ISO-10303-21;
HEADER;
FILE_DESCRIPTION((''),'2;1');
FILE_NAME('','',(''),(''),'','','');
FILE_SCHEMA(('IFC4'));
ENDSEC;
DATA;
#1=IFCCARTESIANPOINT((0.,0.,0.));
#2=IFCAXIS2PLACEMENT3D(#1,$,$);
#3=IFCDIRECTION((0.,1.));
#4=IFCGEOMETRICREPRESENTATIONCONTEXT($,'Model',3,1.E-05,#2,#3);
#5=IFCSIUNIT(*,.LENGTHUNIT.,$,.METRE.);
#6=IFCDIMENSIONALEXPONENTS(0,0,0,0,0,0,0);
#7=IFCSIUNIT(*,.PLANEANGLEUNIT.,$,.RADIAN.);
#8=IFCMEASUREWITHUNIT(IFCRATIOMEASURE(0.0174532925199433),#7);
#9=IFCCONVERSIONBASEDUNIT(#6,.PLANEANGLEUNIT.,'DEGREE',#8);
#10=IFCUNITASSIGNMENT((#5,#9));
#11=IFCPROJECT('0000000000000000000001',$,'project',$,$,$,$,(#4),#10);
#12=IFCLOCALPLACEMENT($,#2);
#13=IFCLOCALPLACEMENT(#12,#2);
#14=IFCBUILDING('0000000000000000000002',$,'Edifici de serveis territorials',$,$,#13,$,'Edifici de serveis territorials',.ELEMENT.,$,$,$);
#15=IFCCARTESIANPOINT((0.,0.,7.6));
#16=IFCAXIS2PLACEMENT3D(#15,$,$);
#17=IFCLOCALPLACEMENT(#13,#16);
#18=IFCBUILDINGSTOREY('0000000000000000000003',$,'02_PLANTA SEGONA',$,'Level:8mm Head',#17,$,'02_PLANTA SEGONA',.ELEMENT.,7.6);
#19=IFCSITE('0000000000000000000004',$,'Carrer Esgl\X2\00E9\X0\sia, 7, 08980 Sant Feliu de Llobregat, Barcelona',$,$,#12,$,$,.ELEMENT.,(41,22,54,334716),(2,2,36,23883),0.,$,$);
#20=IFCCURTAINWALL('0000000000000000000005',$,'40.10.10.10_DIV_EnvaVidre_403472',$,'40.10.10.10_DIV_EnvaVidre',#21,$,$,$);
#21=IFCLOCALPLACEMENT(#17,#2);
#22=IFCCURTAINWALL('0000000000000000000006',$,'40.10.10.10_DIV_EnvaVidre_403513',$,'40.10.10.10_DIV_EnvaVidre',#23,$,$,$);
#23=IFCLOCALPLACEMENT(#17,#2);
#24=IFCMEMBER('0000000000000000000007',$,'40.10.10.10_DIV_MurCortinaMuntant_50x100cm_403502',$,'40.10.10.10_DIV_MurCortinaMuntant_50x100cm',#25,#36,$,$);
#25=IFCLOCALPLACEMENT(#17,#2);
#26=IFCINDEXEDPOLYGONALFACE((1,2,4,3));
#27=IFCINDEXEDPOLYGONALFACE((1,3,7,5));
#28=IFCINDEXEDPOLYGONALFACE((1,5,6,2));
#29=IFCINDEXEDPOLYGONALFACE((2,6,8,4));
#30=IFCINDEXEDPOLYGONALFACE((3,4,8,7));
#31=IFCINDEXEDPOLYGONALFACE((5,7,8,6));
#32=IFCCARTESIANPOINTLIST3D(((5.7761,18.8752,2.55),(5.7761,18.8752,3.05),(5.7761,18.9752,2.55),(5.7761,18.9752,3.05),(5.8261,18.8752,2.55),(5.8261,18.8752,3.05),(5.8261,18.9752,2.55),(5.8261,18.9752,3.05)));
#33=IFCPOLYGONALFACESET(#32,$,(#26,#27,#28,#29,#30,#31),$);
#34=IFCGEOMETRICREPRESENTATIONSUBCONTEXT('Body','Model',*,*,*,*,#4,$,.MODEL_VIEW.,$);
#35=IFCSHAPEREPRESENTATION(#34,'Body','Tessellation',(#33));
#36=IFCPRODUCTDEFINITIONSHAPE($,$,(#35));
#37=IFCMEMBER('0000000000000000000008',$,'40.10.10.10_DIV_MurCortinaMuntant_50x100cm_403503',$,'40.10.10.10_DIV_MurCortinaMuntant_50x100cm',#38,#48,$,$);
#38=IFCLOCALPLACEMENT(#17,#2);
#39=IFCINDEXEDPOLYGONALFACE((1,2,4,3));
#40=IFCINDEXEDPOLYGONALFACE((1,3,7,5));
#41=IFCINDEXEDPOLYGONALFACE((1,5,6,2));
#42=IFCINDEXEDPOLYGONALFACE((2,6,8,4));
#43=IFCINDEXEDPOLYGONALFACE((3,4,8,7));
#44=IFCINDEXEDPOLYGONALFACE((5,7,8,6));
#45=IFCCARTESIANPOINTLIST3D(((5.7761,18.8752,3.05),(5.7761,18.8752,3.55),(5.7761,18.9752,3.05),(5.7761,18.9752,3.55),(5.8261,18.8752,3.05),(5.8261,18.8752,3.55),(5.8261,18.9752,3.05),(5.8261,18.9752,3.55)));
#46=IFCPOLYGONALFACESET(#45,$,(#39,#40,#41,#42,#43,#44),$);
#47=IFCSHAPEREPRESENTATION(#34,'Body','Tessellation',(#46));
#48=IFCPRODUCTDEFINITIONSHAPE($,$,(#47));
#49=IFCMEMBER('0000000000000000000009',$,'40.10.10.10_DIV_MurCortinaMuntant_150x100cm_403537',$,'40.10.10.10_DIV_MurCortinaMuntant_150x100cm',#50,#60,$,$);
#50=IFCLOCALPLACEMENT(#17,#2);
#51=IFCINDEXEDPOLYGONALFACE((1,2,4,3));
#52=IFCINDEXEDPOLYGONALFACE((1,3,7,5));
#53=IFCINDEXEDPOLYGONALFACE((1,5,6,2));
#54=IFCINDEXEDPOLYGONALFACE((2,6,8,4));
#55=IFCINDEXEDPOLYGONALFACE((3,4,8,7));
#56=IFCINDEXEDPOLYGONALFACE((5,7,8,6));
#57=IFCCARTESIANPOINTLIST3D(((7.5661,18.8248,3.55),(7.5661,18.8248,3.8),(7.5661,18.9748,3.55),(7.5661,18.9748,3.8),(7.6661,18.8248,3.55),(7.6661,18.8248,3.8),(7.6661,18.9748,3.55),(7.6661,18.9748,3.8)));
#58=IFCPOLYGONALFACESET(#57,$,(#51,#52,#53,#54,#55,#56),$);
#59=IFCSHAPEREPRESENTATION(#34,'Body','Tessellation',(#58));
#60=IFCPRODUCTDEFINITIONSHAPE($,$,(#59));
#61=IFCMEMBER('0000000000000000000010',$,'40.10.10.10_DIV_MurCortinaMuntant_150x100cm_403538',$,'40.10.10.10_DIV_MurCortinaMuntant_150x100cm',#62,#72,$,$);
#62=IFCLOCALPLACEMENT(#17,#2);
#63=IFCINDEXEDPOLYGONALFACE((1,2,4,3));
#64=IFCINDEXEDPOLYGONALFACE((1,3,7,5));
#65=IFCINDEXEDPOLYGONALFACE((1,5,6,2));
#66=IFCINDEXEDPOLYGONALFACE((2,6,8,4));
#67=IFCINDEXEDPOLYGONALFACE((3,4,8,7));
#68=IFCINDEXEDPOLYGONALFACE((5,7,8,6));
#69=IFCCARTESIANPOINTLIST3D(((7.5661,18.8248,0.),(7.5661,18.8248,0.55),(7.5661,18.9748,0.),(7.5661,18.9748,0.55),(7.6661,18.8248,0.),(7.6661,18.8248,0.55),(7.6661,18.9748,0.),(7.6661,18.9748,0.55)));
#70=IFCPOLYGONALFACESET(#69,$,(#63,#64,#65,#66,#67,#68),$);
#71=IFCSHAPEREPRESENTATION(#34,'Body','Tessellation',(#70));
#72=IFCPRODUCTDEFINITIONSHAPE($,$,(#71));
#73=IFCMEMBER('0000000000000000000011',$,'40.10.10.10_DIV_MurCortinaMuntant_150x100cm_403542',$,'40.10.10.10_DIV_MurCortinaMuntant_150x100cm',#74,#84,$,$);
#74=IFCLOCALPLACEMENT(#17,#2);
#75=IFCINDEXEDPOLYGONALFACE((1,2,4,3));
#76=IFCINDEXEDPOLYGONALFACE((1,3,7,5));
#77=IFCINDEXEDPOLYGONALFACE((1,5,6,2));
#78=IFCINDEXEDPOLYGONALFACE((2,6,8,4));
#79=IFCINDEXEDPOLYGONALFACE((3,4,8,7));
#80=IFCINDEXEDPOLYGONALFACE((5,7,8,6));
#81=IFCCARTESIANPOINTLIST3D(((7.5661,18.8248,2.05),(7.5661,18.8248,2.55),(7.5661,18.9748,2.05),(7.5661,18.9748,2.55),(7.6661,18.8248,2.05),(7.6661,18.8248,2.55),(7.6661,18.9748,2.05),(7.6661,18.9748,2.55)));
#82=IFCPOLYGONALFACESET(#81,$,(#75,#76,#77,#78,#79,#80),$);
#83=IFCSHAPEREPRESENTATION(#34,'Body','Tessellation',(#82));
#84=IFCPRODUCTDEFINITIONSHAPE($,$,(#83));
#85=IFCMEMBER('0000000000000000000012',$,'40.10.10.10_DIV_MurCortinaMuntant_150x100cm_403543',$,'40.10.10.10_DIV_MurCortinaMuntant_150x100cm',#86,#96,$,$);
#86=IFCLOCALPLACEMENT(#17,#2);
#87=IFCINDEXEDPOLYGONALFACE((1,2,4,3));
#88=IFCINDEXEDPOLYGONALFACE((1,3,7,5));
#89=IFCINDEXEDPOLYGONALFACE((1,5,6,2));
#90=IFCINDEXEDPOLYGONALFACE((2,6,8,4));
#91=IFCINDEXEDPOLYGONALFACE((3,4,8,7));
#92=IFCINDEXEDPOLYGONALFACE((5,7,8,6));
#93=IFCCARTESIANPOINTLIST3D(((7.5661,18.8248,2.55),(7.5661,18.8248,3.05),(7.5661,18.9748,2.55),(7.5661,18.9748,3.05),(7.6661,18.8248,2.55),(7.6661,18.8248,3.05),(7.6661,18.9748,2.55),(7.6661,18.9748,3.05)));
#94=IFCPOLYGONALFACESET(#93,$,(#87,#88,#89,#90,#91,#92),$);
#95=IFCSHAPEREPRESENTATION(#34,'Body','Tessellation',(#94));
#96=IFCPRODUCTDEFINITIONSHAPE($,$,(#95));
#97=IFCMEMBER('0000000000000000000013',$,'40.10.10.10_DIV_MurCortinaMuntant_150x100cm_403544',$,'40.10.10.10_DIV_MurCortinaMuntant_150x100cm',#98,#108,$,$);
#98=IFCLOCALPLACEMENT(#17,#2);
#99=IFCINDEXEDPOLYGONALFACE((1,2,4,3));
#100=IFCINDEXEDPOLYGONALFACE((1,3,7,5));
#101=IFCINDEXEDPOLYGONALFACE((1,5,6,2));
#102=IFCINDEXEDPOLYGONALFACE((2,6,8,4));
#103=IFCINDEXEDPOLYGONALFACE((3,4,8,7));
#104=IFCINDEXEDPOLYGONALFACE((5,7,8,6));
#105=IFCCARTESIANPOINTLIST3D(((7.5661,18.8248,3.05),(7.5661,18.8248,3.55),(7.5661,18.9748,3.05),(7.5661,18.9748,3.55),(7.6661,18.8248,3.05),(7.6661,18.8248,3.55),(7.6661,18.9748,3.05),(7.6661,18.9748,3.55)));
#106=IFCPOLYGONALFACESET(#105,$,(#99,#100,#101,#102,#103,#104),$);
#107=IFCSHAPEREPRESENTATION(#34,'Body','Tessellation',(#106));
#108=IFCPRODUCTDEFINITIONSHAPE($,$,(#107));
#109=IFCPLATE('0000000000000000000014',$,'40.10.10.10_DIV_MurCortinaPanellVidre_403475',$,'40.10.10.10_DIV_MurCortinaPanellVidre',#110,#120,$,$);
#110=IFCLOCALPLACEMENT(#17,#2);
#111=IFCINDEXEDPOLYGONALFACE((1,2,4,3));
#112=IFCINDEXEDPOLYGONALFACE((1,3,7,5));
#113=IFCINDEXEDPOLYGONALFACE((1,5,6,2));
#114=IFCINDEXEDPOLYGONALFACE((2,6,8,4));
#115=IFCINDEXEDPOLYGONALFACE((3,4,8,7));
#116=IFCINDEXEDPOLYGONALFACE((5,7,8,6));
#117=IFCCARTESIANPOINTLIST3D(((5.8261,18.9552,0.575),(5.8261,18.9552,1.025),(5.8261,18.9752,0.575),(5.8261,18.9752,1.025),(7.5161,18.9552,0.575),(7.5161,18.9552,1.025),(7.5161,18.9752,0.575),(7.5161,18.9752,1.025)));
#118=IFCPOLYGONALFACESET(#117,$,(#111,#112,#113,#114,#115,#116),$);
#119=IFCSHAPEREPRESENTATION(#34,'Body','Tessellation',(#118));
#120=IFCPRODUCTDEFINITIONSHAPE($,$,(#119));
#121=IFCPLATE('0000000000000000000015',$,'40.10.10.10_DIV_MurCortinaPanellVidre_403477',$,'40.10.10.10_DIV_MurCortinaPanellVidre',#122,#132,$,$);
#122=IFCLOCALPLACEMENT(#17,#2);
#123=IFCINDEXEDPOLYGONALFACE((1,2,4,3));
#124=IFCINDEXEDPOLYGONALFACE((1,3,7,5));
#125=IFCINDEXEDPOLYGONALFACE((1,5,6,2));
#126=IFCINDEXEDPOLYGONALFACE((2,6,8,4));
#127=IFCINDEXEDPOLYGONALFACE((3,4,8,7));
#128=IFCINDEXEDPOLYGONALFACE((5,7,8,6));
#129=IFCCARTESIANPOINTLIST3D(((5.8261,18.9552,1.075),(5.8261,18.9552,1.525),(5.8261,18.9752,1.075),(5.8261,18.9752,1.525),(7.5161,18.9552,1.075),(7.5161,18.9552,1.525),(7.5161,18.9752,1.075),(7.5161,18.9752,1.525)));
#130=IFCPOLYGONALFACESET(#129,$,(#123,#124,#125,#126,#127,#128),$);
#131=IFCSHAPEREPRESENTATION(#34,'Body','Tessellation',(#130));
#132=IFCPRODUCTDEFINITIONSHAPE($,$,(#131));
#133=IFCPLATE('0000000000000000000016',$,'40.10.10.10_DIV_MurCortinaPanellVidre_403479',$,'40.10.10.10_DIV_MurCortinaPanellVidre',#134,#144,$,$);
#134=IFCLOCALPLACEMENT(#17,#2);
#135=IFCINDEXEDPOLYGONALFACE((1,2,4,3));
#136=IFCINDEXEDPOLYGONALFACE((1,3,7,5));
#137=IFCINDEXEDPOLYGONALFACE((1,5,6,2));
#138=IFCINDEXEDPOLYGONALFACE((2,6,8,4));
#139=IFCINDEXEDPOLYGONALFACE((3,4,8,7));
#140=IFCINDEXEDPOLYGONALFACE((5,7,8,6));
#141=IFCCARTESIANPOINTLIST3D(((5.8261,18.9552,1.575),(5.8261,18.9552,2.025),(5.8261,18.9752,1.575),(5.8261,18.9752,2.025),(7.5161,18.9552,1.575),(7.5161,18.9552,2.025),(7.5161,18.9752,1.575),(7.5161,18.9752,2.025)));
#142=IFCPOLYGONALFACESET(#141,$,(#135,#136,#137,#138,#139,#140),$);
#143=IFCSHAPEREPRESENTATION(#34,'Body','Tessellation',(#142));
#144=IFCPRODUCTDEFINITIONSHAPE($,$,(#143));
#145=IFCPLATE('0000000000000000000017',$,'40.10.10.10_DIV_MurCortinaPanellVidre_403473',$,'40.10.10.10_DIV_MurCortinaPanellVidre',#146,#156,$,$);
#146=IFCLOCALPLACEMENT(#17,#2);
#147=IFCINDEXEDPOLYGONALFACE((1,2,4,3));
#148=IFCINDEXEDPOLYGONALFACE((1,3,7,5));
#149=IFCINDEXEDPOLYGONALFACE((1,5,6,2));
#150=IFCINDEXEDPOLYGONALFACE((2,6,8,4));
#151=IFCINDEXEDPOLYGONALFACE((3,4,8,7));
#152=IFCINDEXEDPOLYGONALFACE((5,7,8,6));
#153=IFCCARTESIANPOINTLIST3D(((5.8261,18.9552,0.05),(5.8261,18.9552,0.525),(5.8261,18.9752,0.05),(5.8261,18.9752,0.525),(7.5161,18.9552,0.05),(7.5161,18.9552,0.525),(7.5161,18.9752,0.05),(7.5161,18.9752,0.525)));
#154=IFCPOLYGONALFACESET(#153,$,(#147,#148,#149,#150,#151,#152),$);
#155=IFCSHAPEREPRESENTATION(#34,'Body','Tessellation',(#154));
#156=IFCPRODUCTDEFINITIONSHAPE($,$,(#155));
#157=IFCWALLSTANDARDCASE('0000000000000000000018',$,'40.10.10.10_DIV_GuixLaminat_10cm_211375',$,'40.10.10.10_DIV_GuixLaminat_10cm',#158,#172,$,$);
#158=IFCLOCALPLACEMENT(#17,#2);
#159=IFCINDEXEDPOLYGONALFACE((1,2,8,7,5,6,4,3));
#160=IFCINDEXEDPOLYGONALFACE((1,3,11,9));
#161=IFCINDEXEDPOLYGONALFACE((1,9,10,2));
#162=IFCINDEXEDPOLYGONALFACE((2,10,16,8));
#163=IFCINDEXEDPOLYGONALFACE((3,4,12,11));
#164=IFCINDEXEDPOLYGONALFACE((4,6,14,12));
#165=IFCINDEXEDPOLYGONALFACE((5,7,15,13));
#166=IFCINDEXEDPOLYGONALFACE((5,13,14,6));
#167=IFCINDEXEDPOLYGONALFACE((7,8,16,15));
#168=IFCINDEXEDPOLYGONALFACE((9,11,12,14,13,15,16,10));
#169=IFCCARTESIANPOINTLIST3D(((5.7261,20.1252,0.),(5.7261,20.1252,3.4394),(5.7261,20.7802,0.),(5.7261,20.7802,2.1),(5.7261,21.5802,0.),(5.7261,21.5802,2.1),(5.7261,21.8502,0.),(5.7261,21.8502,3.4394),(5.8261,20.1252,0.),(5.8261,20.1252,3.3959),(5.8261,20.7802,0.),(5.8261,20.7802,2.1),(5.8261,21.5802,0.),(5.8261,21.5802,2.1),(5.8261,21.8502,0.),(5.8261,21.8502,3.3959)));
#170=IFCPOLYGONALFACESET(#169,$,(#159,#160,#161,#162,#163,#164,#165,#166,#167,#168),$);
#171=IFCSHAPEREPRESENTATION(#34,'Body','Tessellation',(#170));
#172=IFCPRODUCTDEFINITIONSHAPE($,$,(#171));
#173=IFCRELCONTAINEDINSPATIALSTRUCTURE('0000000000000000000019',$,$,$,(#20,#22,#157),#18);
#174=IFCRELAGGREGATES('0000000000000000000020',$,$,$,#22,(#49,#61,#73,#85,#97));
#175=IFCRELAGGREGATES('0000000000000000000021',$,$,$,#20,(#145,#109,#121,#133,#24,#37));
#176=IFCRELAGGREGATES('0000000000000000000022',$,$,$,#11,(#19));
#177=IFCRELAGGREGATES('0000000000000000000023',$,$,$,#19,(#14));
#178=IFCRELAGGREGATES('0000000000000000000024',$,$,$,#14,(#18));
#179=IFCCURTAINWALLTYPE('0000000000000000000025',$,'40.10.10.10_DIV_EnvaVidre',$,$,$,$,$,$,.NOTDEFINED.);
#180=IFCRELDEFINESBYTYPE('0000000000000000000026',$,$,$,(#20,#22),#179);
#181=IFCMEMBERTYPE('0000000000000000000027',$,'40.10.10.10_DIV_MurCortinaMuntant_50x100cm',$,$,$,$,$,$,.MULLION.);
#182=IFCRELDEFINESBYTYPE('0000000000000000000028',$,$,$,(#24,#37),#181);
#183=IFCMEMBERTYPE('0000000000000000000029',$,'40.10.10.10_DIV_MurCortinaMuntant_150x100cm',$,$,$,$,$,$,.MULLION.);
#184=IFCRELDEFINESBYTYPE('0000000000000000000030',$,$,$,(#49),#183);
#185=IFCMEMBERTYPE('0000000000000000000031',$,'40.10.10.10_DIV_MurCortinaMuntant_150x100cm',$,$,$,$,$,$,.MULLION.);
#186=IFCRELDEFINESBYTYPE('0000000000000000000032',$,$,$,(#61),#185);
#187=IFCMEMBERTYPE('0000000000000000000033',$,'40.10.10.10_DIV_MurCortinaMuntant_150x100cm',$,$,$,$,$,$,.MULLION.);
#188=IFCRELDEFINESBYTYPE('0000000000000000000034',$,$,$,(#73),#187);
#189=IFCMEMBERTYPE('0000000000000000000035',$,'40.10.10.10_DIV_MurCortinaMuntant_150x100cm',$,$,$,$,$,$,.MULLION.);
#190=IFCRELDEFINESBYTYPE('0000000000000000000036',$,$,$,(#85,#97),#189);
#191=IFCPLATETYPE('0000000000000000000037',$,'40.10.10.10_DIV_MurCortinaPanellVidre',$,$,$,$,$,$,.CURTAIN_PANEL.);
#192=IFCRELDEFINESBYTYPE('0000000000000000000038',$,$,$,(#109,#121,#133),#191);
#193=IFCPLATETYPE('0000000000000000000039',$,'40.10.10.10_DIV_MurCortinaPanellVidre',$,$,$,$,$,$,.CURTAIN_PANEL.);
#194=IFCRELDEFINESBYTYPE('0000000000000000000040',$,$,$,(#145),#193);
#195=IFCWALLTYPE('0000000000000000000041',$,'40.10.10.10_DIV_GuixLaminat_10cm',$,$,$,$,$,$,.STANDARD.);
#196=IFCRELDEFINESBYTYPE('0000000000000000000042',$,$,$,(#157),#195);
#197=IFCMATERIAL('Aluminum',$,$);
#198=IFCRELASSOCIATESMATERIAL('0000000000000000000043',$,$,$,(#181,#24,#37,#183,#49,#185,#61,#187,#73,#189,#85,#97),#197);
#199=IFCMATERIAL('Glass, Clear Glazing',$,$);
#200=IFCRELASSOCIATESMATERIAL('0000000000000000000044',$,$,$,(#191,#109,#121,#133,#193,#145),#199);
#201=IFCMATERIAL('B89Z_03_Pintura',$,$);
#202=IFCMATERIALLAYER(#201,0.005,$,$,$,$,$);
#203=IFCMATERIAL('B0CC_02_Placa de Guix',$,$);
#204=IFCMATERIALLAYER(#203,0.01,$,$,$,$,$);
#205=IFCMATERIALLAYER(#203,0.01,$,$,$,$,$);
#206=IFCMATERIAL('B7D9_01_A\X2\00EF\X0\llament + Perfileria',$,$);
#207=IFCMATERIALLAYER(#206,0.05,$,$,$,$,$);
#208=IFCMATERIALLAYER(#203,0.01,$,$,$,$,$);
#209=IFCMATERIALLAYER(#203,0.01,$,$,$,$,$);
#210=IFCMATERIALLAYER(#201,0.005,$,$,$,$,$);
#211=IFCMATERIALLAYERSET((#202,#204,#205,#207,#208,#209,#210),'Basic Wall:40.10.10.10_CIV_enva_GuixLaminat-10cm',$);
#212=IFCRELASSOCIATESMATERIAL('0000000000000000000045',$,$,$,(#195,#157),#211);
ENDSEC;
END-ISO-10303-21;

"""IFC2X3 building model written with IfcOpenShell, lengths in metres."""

from ifc_helpers import new_model, entity, si_unit, converted_unit, direction, frame, frame_2d, origin, origin_2d_with_axis, place, context, subcontext, project, spatial, polyline, rectangle, extrude, clip, bounded_halfspace, source, transform, mapped, material, layer, layer_set, layer_usage, type_object, type_shapes, element, aggregate, save


model = new_model("IFC2X3")

# Units and contexts
model_context = context("Model", 3, precision=1e-05, world=origin(), true_north=direction((0.0, 1.0)))
body_context = subcontext(model_context, "Body", "Model", "MODEL_VIEW")
ifc_project = project(units=[si_unit("LENGTHUNIT", "METRE"), converted_unit("PLANEANGLEUNIT", "DEGREE", entity("IfcRatioMeasure", 0.0174532925199433), si_unit("PLANEANGLEUNIT", "RADIAN"), dimensions=[0, 0, 0, 0, 0, 0, 0])], contexts=[model_context])

# Site, building, storey
site_placement = place(None, origin())
site = spatial("IfcSite", under=ifc_project, at=site_placement, Name="Carrer Església, 7, 08980 Sant Feliu de Llobregat, Barcelona", CompositionType="ELEMENT", RefLatitude=(41, 22, 54, 334716), RefLongitude=(2, 2, 36, 23883), RefElevation=0.0)
building_placement = place(site_placement, origin())
building = spatial("IfcBuilding", under=site, at=building_placement, Name="Edifici de serveis territorials", LongName="Edifici de serveis territorials", CompositionType="ELEMENT")
storey_placement = place(building_placement, frame((0.0, 0.0, 7.6)))
storey = spatial("IfcBuildingStorey", under=building, at=storey_placement, Name="02_PLANTA SEGONA", ObjectType="Level:8mm Head", LongName="02_PLANTA SEGONA", CompositionType="ELEMENT", Elevation=7.6)

# Curtain walls
curtain_wall_type = type_object("IfcCurtainWallType", Name="40.10.10.10_DIV_EnvaVidre", PredefinedType="NOTDEFINED")
curtain_wall_1_placement = place(storey_placement, frame((0.0, 0.0, -7.6)))
curtain_wall_1 = element("IfcCurtainWall", 1, at=curtain_wall_1_placement, inside=storey, type_object=curtain_wall_type, Name="40.10.10.10_DIV_EnvaVidre_403472", ObjectType="40.10.10.10_DIV_EnvaVidre")
ifc_material_1 = material(Name="Aluminum")
curtain_wall_2_placement = place(storey_placement, frame((0.0, 0.0, -7.6)))
curtain_wall_2 = element("IfcCurtainWall", 2, at=curtain_wall_2_placement, inside=storey, type_object=curtain_wall_type, Name="40.10.10.10_DIV_EnvaVidre_403513", ObjectType="40.10.10.10_DIV_EnvaVidre")

# Members
member_type_1 = type_object("IfcMemberType", Name="40.10.10.10_DIV_MurCortinaMuntant_50x100cm", PredefinedType="MULLION", material=ifc_material_1)
shared_shape_1 = source(origin(), body_context, "Body", "SweptSolid", [
    extrude(rectangle(XDim=0.1, YDim=0.05, at=origin_2d_with_axis()), frame((-0.025, 0.0, -0.5), z_axis=(0.0, 0.0, 1.0), x_axis=(0.0, -1.0, 0.0)), (0.0, 0.0, 1.0), 0.5),
])
type_shapes(member_type_1, [shared_shape_1])
member_1_placement = place(storey_placement, frame((5.7761, 18.9252, 3.05), z_axis=(0.0, 0.0, 1.0), x_axis=(-1.0, 0.0, 0.0)))
member_1 = element("IfcMember", 3, at=member_1_placement, type_object=member_type_1, material=ifc_material_1, Name="40.10.10.10_DIV_MurCortinaMuntant_50x100cm_403502", ObjectType="40.10.10.10_DIV_MurCortinaMuntant_50x100cm", context=body_context, shape_type="MappedRepresentation", body=[
    mapped(shared_shape_1, transform((0.0, 0.0, 0.0), scale=1.0)),
])
member_2_placement = place(storey_placement, frame((5.7761, 18.9252, 3.55), z_axis=(0.0, 0.0, 1.0), x_axis=(-1.0, 0.0, 0.0)))
member_2 = element("IfcMember", 4, at=member_2_placement, type_object=member_type_1, material=ifc_material_1, Name="40.10.10.10_DIV_MurCortinaMuntant_50x100cm_403503", ObjectType="40.10.10.10_DIV_MurCortinaMuntant_50x100cm", context=body_context, shape_type="MappedRepresentation", body=[
    mapped(shared_shape_1, transform((0.0, 0.0, 0.0), scale=1.0)),
])
member_type_2 = type_object("IfcMemberType", Name="40.10.10.10_DIV_MurCortinaMuntant_150x100cm", PredefinedType="MULLION", material=ifc_material_1)
shared_shape_2 = source(origin(), body_context, "Body", "SweptSolid", [
    extrude(rectangle(XDim=0.1, YDim=0.15, at=origin_2d_with_axis()), frame((-0.075, 0.0, -0.25), z_axis=(0.0, 0.0, 1.0), x_axis=(0.0, -1.0, 0.0)), (0.0, 0.0, 1.0), 0.25),
])
type_shapes(member_type_2, [shared_shape_2])
member_3_placement = place(storey_placement, frame((7.6161, 18.9748, 3.8), z_axis=(0.0, 0.0, 1.0), x_axis=(0.0, 1.0, 0.0)))
member_3 = element("IfcMember", 5, at=member_3_placement, type_object=member_type_2, material=ifc_material_1, Name="40.10.10.10_DIV_MurCortinaMuntant_150x100cm_403537", ObjectType="40.10.10.10_DIV_MurCortinaMuntant_150x100cm", context=body_context, shape_type="MappedRepresentation", body=[
    mapped(shared_shape_2, transform((0.0, 0.0, 0.0), scale=1.0)),
])
member_type_3 = type_object("IfcMemberType", Name="40.10.10.10_DIV_MurCortinaMuntant_150x100cm", PredefinedType="MULLION", material=ifc_material_1)
shared_shape_3 = source(origin(), body_context, "Body", "SweptSolid", [
    extrude(rectangle(XDim=0.1, YDim=0.15, at=origin_2d_with_axis()), frame((-0.075, 0.0, -0.55), z_axis=(0.0, 0.0, 1.0), x_axis=(0.0, -1.0, 0.0)), (0.0, 0.0, 1.0), 0.55),
])
type_shapes(member_type_3, [shared_shape_3])
member_4_placement = place(storey_placement, frame((7.6161, 18.9748, 0.55), z_axis=(0.0, 0.0, 1.0), x_axis=(0.0, 1.0, 0.0)))
member_4 = element("IfcMember", 6, at=member_4_placement, type_object=member_type_3, material=ifc_material_1, Name="40.10.10.10_DIV_MurCortinaMuntant_150x100cm_403538", ObjectType="40.10.10.10_DIV_MurCortinaMuntant_150x100cm", context=body_context, shape_type="MappedRepresentation", body=[
    mapped(shared_shape_3, transform((0.0, 0.0, 0.0), scale=1.0)),
])
member_type_4 = type_object("IfcMemberType", Name="40.10.10.10_DIV_MurCortinaMuntant_150x100cm", PredefinedType="MULLION", material=ifc_material_1)
shared_shape_4 = source(origin(), body_context, "Body", "SweptSolid", [
    extrude(rectangle(XDim=0.1, YDim=0.15, at=origin_2d_with_axis()), frame((-0.075, 0.0, -0.5), z_axis=(0.0, 0.0, 1.0), x_axis=(0.0, -1.0, 0.0)), (0.0, 0.0, 1.0), 0.5),
])
type_shapes(member_type_4, [shared_shape_4])
member_5_placement = place(storey_placement, frame((7.6161, 18.9748, 2.55), z_axis=(0.0, 0.0, 1.0), x_axis=(0.0, 1.0, 0.0)))
member_5 = element("IfcMember", 7, at=member_5_placement, type_object=member_type_4, material=ifc_material_1, Name="40.10.10.10_DIV_MurCortinaMuntant_150x100cm_403542", ObjectType="40.10.10.10_DIV_MurCortinaMuntant_150x100cm", context=body_context, shape_type="MappedRepresentation", body=[
    mapped(shared_shape_4, transform((0.0, 0.0, 0.0), scale=1.0)),
])
member_type_5 = type_object("IfcMemberType", Name="40.10.10.10_DIV_MurCortinaMuntant_150x100cm", PredefinedType="MULLION", material=ifc_material_1)
shared_shape_5 = source(origin(), body_context, "Body", "SweptSolid", [
    extrude(rectangle(XDim=0.1, YDim=0.15, at=origin_2d_with_axis()), frame((-0.075, 0.0, -0.5), z_axis=(0.0, 0.0, 1.0), x_axis=(0.0, -1.0, 0.0)), (0.0, 0.0, 1.0), 0.5),
])
type_shapes(member_type_5, [shared_shape_5])
member_6_placement = place(storey_placement, frame((7.6161, 18.9748, 3.05), z_axis=(0.0, 0.0, 1.0), x_axis=(0.0, 1.0, 0.0)))
member_6 = element("IfcMember", 8, at=member_6_placement, type_object=member_type_5, material=ifc_material_1, Name="40.10.10.10_DIV_MurCortinaMuntant_150x100cm_403543", ObjectType="40.10.10.10_DIV_MurCortinaMuntant_150x100cm", context=body_context, shape_type="MappedRepresentation", body=[
    mapped(shared_shape_5, transform((0.0, 0.0, 0.0), scale=1.0)),
])
member_7_placement = place(storey_placement, frame((7.6161, 18.9748, 3.55), z_axis=(0.0, 0.0, 1.0), x_axis=(0.0, 1.0, 0.0)))
member_7 = element("IfcMember", 9, at=member_7_placement, type_object=member_type_5, material=ifc_material_1, Name="40.10.10.10_DIV_MurCortinaMuntant_150x100cm_403544", ObjectType="40.10.10.10_DIV_MurCortinaMuntant_150x100cm", context=body_context, shape_type="MappedRepresentation", body=[
    mapped(shared_shape_5, transform((0.0, 0.0, 0.0), scale=1.0)),
])
aggregate(curtain_wall_2, [member_3, member_4, member_5, member_6, member_7])

# Plates
ifc_material_2 = material(Name="Glass, Clear Glazing")
plate_type_1 = type_object("IfcPlateType", Name="40.10.10.10_DIV_MurCortinaPanellVidre", PredefinedType="CURTAIN_PANEL", material=ifc_material_2)
shared_shape_6 = source(origin(), body_context, "Body", "SweptSolid", [
    extrude(rectangle(XDim=0.02, YDim=1.69, at=frame_2d((0.0, 0.0), x_axis=(1.0, 0.0))), frame((0.845, 0.01, 0.0), z_axis=(0.0, 0.0, 1.0), x_axis=(0.0, 1.0, 0.0)), (0.0, 0.0, 1.0), 0.45),
])
type_shapes(plate_type_1, [shared_shape_6])
plate_1_placement = place(curtain_wall_1_placement, frame((5.8261, 18.9552, 8.175)))
plate_1 = element("IfcPlate", 10, at=plate_1_placement, type_object=plate_type_1, material=ifc_material_2, Name="40.10.10.10_DIV_MurCortinaPanellVidre_403475", ObjectType="40.10.10.10_DIV_MurCortinaPanellVidre", context=body_context, shape_type="MappedRepresentation", body=[
    mapped(shared_shape_6, transform((0.0, 0.0, 0.0), scale=1.0)),
])
plate_2_placement = place(curtain_wall_1_placement, frame((5.8261, 18.9552, 8.675)))
plate_2 = element("IfcPlate", 11, at=plate_2_placement, type_object=plate_type_1, material=ifc_material_2, Name="40.10.10.10_DIV_MurCortinaPanellVidre_403477", ObjectType="40.10.10.10_DIV_MurCortinaPanellVidre", context=body_context, shape_type="MappedRepresentation", body=[
    mapped(shared_shape_6, transform((0.0, 0.0, 0.0), scale=1.0)),
])
plate_3_placement = place(curtain_wall_1_placement, frame((5.8261, 18.9552, 9.175)))
plate_3 = element("IfcPlate", 12, at=plate_3_placement, type_object=plate_type_1, material=ifc_material_2, Name="40.10.10.10_DIV_MurCortinaPanellVidre_403479", ObjectType="40.10.10.10_DIV_MurCortinaPanellVidre", context=body_context, shape_type="MappedRepresentation", body=[
    mapped(shared_shape_6, transform((0.0, 0.0, 0.0), scale=1.0)),
])
plate_type_2 = type_object("IfcPlateType", Name="40.10.10.10_DIV_MurCortinaPanellVidre", PredefinedType="CURTAIN_PANEL", material=ifc_material_2)
shared_shape_7 = source(origin(), body_context, "Body", "SweptSolid", [
    extrude(rectangle(XDim=0.02, YDim=1.69, at=frame_2d((0.0, 0.0), x_axis=(1.0, 0.0))), frame((0.845, 0.01, 0.0), z_axis=(0.0, 0.0, 1.0), x_axis=(0.0, 1.0, 0.0)), (0.0, 0.0, 1.0), 0.475),
])
type_shapes(plate_type_2, [shared_shape_7])
plate_4_placement = place(curtain_wall_1_placement, frame((5.8261, 18.9552, 7.65)))
plate_4 = element("IfcPlate", 13, at=plate_4_placement, type_object=plate_type_2, material=ifc_material_2, Name="40.10.10.10_DIV_MurCortinaPanellVidre_403473", ObjectType="40.10.10.10_DIV_MurCortinaPanellVidre", context=body_context, shape_type="MappedRepresentation", body=[
    mapped(shared_shape_7, transform((0.0, 0.0, 0.0), scale=1.0)),
])
aggregate(curtain_wall_1, [plate_4, plate_1, plate_2, plate_3, member_1, member_2])

# Wall, opening
ifc_material_3 = material(Name="B89Z_03_Pintura")
ifc_layer_1 = layer(ifc_material_3, 0.005)
ifc_material_4 = material(Name="B0CC_02_Placa de Guix")
ifc_layer_2 = layer(ifc_material_4, 0.01)
ifc_layer_3 = layer(ifc_material_4, 0.01)
ifc_material_5 = material(Name="B7D9_01_Aïllament + Perfileria")
ifc_layer_4 = layer(ifc_material_5, 0.05)
ifc_layer_5 = layer(ifc_material_4, 0.01)
ifc_layer_6 = layer(ifc_material_4, 0.01)
ifc_layer_7 = layer(ifc_material_3, 0.005)
ifc_layer_set_1 = layer_set([ifc_layer_1, ifc_layer_2, ifc_layer_3, ifc_layer_4, ifc_layer_5, ifc_layer_6, ifc_layer_7], Name="Basic Wall:40.10.10.10_CIV_enva_GuixLaminat-10cm")
ifc_layer_usage_1 = layer_usage(ifc_layer_set_1, "AXIS2", "NEGATIVE", 0.05)
wall_type_1 = type_object("IfcWallType", Name="40.10.10.10_DIV_GuixLaminat_10cm", PredefinedType="STANDARD", material=ifc_layer_set_1)
wall_1_placement = place(storey_placement, frame((5.7761, 21.8502, 0.0), z_axis=(0.0, 0.0, 1.0), x_axis=(0.0, -1.0, 0.0)))
wall_1 = element("IfcWallStandardCase", 14, at=wall_1_placement, inside=storey, type_object=wall_type_1, material=ifc_layer_usage_1, Name="40.10.10.10_DIV_GuixLaminat_10cm_211375", ObjectType="40.10.10.10_DIV_GuixLaminat_10cm", context=body_context, shape_type="Clipping", body=[
    clip(extrude(rectangle(XDim=1.725, YDim=0.1, at=frame_2d((0.8625, 0.0), x_axis=(-1.0, 0.0))), origin(), (0.0, 0.0, 1.0), 3.4394), bounded_halfspace(frame((0.0, -0.05, 3.4394), z_axis=(0.0, -0.398319, -0.917247), x_axis=(-1.0, 0.0, 0.0)), True, frame((0.0, -0.05, 3.4394)), polyline([(0.0, 0.0), (1.725, 0.0), (1.725, 0.1), (0.15, 0.1), (0.0, 0.1), (0.0, 0.0)]))),
])
opening_1_placement = place(wall_1_placement, frame((1.07, 0.05, 0.0)))
element("IfcOpeningElement", 15, at=opening_1_placement, cuts=wall_1, ObjectType="Opening", context=body_context, shape_type="SweptSolid", body=[
    extrude(rectangle(XDim=2.1, YDim=0.8, at=frame_2d((1.05, 0.4), x_axis=(1.0, 0.0))), frame((0.0, 0.0, 0.0), z_axis=(0.0, -1.0, 0.0), x_axis=(0.0, 0.0, 1.0)), (0.0, 0.0, 1.0), 0.1),
])

save(model, "model.ifc")
